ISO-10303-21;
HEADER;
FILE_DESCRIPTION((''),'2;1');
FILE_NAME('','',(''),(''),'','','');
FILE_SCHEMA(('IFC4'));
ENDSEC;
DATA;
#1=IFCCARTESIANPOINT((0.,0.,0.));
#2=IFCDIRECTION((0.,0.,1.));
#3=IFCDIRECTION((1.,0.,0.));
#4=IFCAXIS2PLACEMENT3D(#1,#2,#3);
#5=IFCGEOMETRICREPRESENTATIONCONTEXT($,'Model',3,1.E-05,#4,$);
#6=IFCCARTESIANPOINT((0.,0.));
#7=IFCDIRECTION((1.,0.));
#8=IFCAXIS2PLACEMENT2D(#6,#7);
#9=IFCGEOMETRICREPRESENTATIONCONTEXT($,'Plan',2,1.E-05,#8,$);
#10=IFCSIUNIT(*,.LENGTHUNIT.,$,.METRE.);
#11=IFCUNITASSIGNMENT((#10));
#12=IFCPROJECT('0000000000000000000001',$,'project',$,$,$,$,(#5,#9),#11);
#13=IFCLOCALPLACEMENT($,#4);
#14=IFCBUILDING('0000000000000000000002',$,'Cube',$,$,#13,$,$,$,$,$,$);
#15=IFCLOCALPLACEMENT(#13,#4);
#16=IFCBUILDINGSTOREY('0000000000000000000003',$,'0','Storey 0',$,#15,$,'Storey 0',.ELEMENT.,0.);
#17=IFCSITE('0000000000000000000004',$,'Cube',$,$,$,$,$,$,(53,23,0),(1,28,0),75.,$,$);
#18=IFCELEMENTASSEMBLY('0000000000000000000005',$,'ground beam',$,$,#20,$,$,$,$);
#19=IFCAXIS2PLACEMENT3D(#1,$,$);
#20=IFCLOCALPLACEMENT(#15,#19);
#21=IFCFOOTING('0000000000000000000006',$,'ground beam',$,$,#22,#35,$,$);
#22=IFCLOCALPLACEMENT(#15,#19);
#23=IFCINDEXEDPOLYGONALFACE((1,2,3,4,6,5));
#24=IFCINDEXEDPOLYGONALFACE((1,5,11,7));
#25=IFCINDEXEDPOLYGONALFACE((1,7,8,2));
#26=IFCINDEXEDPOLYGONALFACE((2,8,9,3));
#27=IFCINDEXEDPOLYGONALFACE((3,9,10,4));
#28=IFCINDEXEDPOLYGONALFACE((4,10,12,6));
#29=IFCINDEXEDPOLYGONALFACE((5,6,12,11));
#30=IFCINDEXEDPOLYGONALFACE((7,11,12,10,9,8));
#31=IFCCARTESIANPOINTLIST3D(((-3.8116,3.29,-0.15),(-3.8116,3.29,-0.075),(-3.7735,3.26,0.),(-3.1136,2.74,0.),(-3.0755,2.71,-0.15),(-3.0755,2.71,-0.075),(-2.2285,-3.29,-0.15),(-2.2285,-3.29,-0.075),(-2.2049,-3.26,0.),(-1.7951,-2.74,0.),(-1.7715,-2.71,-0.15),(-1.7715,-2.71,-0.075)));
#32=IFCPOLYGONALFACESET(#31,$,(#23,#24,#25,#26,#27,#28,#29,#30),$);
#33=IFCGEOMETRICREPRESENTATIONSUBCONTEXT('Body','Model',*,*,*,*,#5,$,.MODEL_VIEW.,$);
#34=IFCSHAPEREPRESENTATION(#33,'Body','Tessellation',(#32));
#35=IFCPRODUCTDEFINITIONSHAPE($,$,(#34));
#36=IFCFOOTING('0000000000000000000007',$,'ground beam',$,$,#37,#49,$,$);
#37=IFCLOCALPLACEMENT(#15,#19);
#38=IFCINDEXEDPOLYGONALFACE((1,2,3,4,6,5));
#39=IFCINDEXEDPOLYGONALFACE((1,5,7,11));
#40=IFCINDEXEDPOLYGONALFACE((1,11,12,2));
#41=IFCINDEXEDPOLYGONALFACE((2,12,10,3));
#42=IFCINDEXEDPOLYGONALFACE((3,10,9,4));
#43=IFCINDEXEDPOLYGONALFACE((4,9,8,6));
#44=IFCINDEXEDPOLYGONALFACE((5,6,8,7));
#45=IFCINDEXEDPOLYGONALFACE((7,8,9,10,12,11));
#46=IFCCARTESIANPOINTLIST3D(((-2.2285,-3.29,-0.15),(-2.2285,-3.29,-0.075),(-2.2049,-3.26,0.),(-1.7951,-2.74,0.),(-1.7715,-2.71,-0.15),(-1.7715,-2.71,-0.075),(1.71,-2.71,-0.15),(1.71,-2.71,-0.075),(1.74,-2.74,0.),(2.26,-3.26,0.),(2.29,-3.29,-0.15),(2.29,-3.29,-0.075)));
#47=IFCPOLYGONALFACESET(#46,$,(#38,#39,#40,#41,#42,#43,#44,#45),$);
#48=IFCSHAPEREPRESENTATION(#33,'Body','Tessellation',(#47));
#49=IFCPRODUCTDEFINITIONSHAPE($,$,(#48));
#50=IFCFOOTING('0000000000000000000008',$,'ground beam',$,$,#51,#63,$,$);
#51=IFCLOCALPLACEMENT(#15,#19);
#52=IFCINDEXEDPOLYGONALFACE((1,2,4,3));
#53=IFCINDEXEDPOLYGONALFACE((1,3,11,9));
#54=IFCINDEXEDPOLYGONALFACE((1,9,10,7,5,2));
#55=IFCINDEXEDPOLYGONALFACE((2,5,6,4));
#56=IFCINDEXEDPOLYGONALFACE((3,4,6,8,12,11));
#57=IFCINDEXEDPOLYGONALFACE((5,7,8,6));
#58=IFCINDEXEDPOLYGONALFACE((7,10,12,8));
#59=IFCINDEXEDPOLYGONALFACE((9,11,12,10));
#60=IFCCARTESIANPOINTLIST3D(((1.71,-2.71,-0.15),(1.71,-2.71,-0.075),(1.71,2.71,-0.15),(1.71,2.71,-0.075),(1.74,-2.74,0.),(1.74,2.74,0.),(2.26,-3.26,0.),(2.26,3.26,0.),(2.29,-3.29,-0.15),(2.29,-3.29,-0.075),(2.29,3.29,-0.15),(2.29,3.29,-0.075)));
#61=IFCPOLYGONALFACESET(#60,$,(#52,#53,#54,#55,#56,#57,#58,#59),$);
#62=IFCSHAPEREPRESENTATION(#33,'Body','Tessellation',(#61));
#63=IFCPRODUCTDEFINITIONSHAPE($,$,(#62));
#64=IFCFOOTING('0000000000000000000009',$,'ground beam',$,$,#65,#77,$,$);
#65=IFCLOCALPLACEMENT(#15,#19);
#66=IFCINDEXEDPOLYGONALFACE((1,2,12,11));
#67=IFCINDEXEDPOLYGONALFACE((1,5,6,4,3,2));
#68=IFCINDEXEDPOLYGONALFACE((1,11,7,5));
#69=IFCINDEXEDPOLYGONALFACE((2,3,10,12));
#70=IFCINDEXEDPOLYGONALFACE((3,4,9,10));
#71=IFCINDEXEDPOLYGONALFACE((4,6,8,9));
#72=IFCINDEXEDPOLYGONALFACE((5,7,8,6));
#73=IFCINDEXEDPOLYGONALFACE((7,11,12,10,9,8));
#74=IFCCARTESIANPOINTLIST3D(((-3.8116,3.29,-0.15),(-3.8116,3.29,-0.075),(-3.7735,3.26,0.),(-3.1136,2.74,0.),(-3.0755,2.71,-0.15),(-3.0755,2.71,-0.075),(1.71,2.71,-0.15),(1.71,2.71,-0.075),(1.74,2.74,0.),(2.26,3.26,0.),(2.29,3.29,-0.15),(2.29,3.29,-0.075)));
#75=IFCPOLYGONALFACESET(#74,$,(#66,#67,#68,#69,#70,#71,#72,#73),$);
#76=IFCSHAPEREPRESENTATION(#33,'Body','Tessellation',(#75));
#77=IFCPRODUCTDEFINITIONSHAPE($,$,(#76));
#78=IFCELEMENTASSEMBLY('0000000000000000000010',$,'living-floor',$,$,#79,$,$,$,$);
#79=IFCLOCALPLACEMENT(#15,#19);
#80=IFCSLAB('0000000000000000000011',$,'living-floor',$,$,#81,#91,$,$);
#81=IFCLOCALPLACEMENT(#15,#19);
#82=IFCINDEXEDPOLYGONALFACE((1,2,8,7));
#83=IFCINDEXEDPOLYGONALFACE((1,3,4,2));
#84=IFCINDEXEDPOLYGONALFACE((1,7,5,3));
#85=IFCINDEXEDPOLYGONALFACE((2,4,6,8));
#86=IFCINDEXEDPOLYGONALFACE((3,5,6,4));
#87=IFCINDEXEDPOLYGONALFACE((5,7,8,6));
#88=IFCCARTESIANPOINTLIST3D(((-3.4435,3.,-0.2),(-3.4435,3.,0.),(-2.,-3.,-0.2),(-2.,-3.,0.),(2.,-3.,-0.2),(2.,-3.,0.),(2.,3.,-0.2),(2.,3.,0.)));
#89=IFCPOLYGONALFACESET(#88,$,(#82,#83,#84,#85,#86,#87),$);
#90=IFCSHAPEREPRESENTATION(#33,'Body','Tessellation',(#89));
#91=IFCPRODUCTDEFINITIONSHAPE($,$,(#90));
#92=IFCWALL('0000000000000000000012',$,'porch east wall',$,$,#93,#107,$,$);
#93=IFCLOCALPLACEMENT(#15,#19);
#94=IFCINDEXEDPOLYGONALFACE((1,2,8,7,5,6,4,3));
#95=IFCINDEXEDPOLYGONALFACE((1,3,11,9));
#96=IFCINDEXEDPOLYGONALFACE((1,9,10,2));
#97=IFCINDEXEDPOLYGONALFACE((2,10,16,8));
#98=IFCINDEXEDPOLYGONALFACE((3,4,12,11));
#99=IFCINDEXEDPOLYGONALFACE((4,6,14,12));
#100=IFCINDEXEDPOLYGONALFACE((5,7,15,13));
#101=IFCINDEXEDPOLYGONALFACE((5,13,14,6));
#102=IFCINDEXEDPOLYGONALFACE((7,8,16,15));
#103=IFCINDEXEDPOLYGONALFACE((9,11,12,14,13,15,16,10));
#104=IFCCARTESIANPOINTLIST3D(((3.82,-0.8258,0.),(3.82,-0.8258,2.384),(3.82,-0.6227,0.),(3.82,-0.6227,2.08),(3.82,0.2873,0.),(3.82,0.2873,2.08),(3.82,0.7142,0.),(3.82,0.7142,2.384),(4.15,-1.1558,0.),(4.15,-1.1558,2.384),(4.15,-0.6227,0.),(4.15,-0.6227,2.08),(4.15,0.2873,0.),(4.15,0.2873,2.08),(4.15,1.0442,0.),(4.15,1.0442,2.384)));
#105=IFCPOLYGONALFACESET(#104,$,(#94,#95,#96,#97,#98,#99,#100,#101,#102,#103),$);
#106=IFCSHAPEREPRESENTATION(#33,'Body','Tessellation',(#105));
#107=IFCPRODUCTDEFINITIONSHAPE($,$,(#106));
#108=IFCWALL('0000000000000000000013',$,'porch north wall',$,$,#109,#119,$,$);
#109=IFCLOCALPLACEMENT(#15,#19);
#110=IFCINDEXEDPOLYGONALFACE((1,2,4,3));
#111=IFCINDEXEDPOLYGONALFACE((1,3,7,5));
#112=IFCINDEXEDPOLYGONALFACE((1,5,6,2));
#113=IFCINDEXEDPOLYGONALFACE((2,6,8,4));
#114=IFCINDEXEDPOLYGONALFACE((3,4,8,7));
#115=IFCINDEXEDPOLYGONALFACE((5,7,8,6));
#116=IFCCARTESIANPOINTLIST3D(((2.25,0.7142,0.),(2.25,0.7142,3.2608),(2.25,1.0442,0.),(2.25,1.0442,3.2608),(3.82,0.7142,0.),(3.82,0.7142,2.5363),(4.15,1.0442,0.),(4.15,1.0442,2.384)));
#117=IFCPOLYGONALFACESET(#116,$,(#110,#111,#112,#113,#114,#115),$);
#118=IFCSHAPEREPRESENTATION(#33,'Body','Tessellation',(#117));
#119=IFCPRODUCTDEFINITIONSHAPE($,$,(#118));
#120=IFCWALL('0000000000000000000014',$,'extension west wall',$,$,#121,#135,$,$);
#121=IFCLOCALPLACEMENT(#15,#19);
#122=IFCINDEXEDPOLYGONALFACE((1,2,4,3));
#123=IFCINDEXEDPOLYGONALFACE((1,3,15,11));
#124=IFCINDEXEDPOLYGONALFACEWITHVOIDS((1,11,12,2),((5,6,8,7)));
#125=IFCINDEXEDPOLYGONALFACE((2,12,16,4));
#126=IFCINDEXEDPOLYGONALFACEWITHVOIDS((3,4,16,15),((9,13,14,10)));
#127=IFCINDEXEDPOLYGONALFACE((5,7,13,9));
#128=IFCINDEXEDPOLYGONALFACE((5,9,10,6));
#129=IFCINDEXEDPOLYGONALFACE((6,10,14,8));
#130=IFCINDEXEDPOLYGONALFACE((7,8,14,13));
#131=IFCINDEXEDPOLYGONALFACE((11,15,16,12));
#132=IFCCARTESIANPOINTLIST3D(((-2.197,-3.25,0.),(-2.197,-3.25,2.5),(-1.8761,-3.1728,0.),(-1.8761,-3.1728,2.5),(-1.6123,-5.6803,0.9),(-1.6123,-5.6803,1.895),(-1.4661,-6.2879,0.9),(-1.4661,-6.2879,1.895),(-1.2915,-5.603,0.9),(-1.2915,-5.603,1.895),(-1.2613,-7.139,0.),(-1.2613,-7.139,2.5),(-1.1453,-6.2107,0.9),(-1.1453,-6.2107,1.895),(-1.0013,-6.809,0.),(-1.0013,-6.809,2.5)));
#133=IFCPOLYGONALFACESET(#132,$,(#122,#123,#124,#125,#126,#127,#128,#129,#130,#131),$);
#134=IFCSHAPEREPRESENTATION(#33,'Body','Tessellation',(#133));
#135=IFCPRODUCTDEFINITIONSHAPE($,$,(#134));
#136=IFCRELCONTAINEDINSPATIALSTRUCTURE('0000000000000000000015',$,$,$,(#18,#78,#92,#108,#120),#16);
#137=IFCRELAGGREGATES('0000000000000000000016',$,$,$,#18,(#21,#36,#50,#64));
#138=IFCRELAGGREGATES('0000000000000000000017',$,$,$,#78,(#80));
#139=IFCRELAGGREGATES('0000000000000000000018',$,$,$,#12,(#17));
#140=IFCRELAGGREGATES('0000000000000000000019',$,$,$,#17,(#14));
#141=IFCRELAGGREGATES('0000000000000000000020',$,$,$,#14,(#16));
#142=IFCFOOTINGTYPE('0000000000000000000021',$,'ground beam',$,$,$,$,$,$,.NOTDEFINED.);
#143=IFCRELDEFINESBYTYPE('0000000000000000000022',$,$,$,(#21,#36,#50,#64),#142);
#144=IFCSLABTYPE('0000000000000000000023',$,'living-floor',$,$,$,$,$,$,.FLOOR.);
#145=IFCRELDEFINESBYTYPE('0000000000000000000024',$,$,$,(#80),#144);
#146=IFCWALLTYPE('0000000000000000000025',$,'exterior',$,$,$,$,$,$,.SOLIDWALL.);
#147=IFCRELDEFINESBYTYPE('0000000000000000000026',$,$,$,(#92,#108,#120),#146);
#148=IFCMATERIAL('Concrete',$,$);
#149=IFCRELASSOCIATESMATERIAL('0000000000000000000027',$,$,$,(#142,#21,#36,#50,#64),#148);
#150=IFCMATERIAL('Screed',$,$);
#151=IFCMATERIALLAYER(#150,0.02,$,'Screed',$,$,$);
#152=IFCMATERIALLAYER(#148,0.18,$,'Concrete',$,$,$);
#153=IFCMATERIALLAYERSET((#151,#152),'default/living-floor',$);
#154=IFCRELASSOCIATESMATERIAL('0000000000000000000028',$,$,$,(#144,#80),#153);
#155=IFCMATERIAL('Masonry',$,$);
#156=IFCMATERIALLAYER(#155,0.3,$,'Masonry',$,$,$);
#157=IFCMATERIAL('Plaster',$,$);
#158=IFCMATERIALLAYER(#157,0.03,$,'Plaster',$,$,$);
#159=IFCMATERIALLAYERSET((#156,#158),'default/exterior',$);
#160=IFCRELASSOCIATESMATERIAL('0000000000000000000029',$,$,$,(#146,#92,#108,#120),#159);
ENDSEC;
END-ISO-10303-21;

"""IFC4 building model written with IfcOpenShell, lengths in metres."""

from ifc_helpers import new_model, si_unit, frame, origin, origin_with_axes, origin_2d_with_axis, place, context, subcontext, project, spatial, polyline, line, indexed_curve, outline, extrude, clip, halfspace, source, transform, mapped, material, layer, layer_set, layer_usage, material_profile, profile_set, profile_usage, type_object, element, aggregate, save


model = new_model("IFC4")

# Units and contexts
model_context = context("Model", 3, precision=1e-05, world=origin_with_axes())
plan_context = context("Plan", 2, precision=1e-05, world=origin_2d_with_axis())
body_context = subcontext(model_context, "Body", "Model", "MODEL_VIEW")
ifc_project = project(units=[si_unit("LENGTHUNIT", "METRE")], contexts=[model_context, plan_context])

# Site, building, storey
site = spatial("IfcSite", under=ifc_project, Name="Cube", RefLatitude=(53, 23, 0), RefLongitude=(1, 28, 0), RefElevation=75.0)
building_placement = place(None, origin_with_axes())
building = spatial("IfcBuilding", under=site, at=building_placement, Name="Cube")
storey_placement = place(building_placement, origin_with_axes())
storey = spatial("IfcBuildingStorey", under=building, at=storey_placement, Name="0", Description="Storey 0", LongName="Storey 0", CompositionType="ELEMENT", Elevation=0.0)

# Element assembly, footings
assembly_1_placement = place(storey_placement, origin_with_axes())
assembly_1 = element("IfcElementAssembly", 1, at=assembly_1_placement, inside=storey, Name="ground beam")
ifc_material_1 = material(Name="Concrete")
ifc_material_profile = material_profile(ifc_material_1, outline(polyline([(-0.26, 0.0), (-0.29, -0.075), (-0.29, -0.15), (0.29, -0.15), (0.29, -0.075), (0.26, 0.0), (-0.26, 0.0)])))
ifc_profile_set = profile_set([ifc_material_profile])
ifc_profile_usage_1 = profile_usage(ifc_profile_set)
footing_type = type_object("IfcFootingType", Name="ground beam", PredefinedType="NOTDEFINED", material=ifc_profile_set)
footing_1_placement = place(assembly_1_placement, frame((-1.7661, -3.9723, 0.0), z_axis=(-0.233915, 0.972257, 0.0), x_axis=(-0.972257, -0.233915, 0.0)))
footing_1 = element("IfcFooting", 2, at=footing_1_placement, type_object=footing_type, material=ifc_profile_usage_1, Name="ground beam", context=body_context, shape_type="Clipping", body=[
    clip(clip(extrude(outline(polyline([(-0.26, 0.0), (-0.29, -0.075), (-0.29, -0.15), (0.29, -0.15), (0.29, -0.075), (0.26, 0.0), (-0.26, 0.0)])), origin_with_axes(), (0.0, 0.0, 1.0), 8.1712), halfspace(frame((0.0, 0.0, 1.0), z_axis=(-0.618904, 0.0, -0.785467), x_axis=(0.0, 1.0, 0.0)), False)), halfspace(frame((0.0, 0.0, 7.1712), z_axis=(-0.785467, 0.0, 0.618904), x_axis=(0.0, 1.0, 0.0)), False)),
])
ifc_profile_usage_2 = profile_usage(ifc_profile_set)
footing_2_placement = place(assembly_1_placement, frame((3.0, -3.0, 0.0), z_axis=(-1.0, 0.0, 0.0), x_axis=(0.0, -1.0, 0.0)))
footing_2 = element("IfcFooting", 3, at=footing_2_placement, type_object=footing_type, material=ifc_profile_usage_2, Name="ground beam", context=body_context, shape_type="Clipping", body=[
    clip(clip(extrude(outline(polyline([(-0.26, 0.0), (-0.29, -0.075), (-0.29, -0.15), (0.29, -0.15), (0.29, -0.075), (0.26, 0.0), (-0.26, 0.0)])), origin_with_axes(), (0.0, 0.0, 1.0), 6.0), halfspace(frame((0.0, 0.0, 1.0), z_axis=(-0.707107, 0.0, -0.707107), x_axis=(0.0, 1.0, 0.0)), False)), halfspace(frame((0.0, 0.0, 5.0), z_axis=(-0.618904, 0.0, 0.785467), x_axis=(0.0, 1.0, 0.0)), False)),
])
ifc_profile_usage_3 = profile_usage(ifc_profile_set)
footing_3_placement = place(assembly_1_placement, frame((2.0, 4.0, 0.0), z_axis=(0.0, -1.0, 0.0), x_axis=(1.0, 0.0, 0.0)))
footing_3 = element("IfcFooting", 4, at=footing_3_placement, type_object=footing_type, material=ifc_profile_usage_3, Name="ground beam", context=body_context, shape_type="Clipping", body=[
    clip(clip(extrude(outline(polyline([(-0.26, 0.0), (-0.29, -0.075), (-0.29, -0.15), (0.29, -0.15), (0.29, -0.075), (0.26, 0.0), (-0.26, 0.0)])), origin_with_axes(), (0.0, 0.0, 1.0), 8.0), halfspace(frame((0.0, 0.0, 1.0), z_axis=(-0.707107, 0.0, -0.707107), x_axis=(0.0, 1.0, 0.0)), False)), halfspace(frame((0.0, 0.0, 7.0), z_axis=(-0.707107, 0.0, 0.707107), x_axis=(0.0, 1.0, 0.0)), False)),
])
ifc_profile_usage_4 = profile_usage(ifc_profile_set)
footing_4_placement = place(assembly_1_placement, frame((-4.4435, 3.0, 0.0), z_axis=(1.0, 0.0, 0.0), x_axis=(0.0, 1.0, 0.0)))
footing_4 = element("IfcFooting", 5, at=footing_4_placement, type_object=footing_type, material=ifc_profile_usage_4, Name="ground beam", context=body_context, shape_type="Clipping", body=[
    clip(clip(extrude(outline(polyline([(-0.26, 0.0), (-0.29, -0.075), (-0.29, -0.15), (0.29, -0.15), (0.29, -0.075), (0.26, 0.0), (-0.26, 0.0)])), origin_with_axes(), (0.0, 0.0, 1.0), 7.4435), halfspace(frame((0.0, 0.0, 1.0), z_axis=(-0.785467, 0.0, -0.618904), x_axis=(0.0, 1.0, 0.0)), False)), halfspace(frame((0.0, 0.0, 6.4435), z_axis=(-0.707107, 0.0, 0.707107), x_axis=(0.0, 1.0, 0.0)), False)),
])
aggregate(assembly_1, [footing_1, footing_2, footing_3, footing_4])

# Element assembly, slab
assembly_2_placement = place(storey_placement, origin_with_axes())
assembly_2 = element("IfcElementAssembly", 6, at=assembly_2_placement, inside=storey, Name="living-floor")
ifc_material_2 = material(Name="Screed")
ifc_layer_1 = layer(ifc_material_2, 0.02, Name="Screed")
ifc_layer_2 = layer(ifc_material_1, 0.18, Name="Concrete")
ifc_layer_set_1 = layer_set([ifc_layer_1, ifc_layer_2], Name="default/living-floor")
ifc_layer_usage_1 = layer_usage(ifc_layer_set_1, "AXIS3", "POSITIVE", 0.0)
slab_type = type_object("IfcSlabType", Name="living-floor", PredefinedType="FLOOR", material=ifc_layer_set_1)
slab_placement = place(assembly_2_placement, frame((2.0, 3.0, -0.2), z_axis=(0.0, 0.0, -1.0), x_axis=(0.0, 1.0, 0.0)))
slab = element("IfcSlab", 7, at=slab_placement, type_object=slab_type, material=ifc_layer_usage_1, Name="living-floor", context=body_context, shape_type="SweptSolid", body=[
    extrude(outline(polyline([(0.0, 0.0), (-6.0, 0.0), (-6.0, -4.0), (0.0, -5.4435), (0.0, 0.0)])), origin(), (0.0, 0.0, -1.0), 0.2),
])
aggregate(assembly_2, [slab])

# Wall, opening
ifc_material_3 = material(Name="Masonry")
ifc_layer_3 = layer(ifc_material_3, 0.3, Name="Masonry")
ifc_material_4 = material(Name="Plaster")
ifc_layer_4 = layer(ifc_material_4, 0.03, Name="Plaster")
ifc_layer_set_2 = layer_set([ifc_layer_3, ifc_layer_4], Name="default/exterior")
wall_type = type_object("IfcWallType", Name="exterior", PredefinedType="SOLIDWALL", material=ifc_layer_set_2)
ifc_layer_usage_2 = layer_usage(ifc_layer_set_2, "AXIS2", "POSITIVE", 0.0)
wall_1_placement = place(storey_placement, frame((4.15, -1.1558, 0.0), z_axis=(0.0, 0.0, 1.0), x_axis=(0.0, 1.0, 0.0)))
wall_1 = element("IfcWall", 8, at=wall_1_placement, inside=storey, type_object=wall_type, material=ifc_layer_usage_2, Name="porch east wall", context=body_context, shape_type="SweptSolid", body=[
    extrude(outline(indexed_curve([(0.0, 0.0), (0.33, 0.33), (1.87, 0.33), (2.2, 0.0)], segments=[line(1, 2, 3, 4, 1)])), origin_with_axes(), (0.0, 0.0, 1.0), 2.384),
])
shared_shape = source(origin_with_axes(), body_context, "Body", "SweptSolid", [
    extrude(outline(indexed_curve([(0.0, 0.0), (0.91, 0.0), (0.91, 2.08), (0.0, 2.08)], segments=[line(1, 2, 3, 4, 1)])), frame((0.0, -0.6, 0.0), z_axis=(0.0, -1.0, 0.0), x_axis=(1.0, 0.0, 0.0)), (0.0, 0.0, -1.0), 1.2),
])
opening_1_placement = place(wall_1_placement, frame((0.5331, 0.0, 0.0), z_axis=(0.0, 0.0, 1.0), x_axis=(1.0, 0.0, 0.0)))
element("IfcOpeningElement", 9, at=opening_1_placement, cuts=wall_1, PredefinedType="OPENING", context=body_context, shape_type="MappedRepresentation", body=[
    mapped(shared_shape, transform((0.0, 0.0, 0.0), x_axis=(1.0, 0.0, 0.0), y_axis=(0.0, 1.0, 0.0), z_axis=(0.0, 0.0, 1.0), scale=1.0)),
])

# Wall
ifc_layer_usage_3 = layer_usage(ifc_layer_set_2, "AXIS2", "POSITIVE", 0.0)
wall_2_placement = place(storey_placement, frame((4.15, 1.0442, 0.0), z_axis=(0.0, 0.0, 1.0), x_axis=(-1.0, 0.0, 0.0)))
element("IfcWall", 10, at=wall_2_placement, inside=storey, type_object=wall_type, material=ifc_layer_usage_3, Name="porch north wall", context=body_context, shape_type="Clipping", body=[
    clip(extrude(outline(indexed_curve([(0.0, 0.0), (1.9, 0.0), (1.9, 0.33), (0.33, 0.33)], segments=[line(1, 2, 3, 4, 1)])), origin_with_axes(), (0.0, 0.0, 1.0), 3.5), halfspace(frame((0.0, 0.0, 2.384), z_axis=(-0.419, 0.0, 0.908), x_axis=(0.0, 1.0, 0.0)), False)),
])

# Wall, opening
ifc_layer_usage_4 = layer_usage(ifc_layer_set_2, "AXIS2", "POSITIVE", 0.0)
wall_3_placement = place(storey_placement, frame((-2.197, -3.25, 0.0), z_axis=(0.0, 0.0, 1.0), x_axis=(0.233916, -0.972257, 0.0)))
wall_3 = element("IfcWall", 11, at=wall_3_placement, inside=storey, type_object=wall_type, material=ifc_layer_usage_4, Name="extension west wall", context=body_context, shape_type="SweptSolid", body=[
    extrude(outline(indexed_curve([(0.0, 0.0), (0.0, 0.33), (3.7399, 0.33), (4.0, 0.0)], segments=[line(1, 2, 3, 4, 1)])), origin_with_axes(), (0.0, 0.0, 1.0), 2.5),
])
opening_2_placement = place(wall_3_placement, frame((2.4996, -0.0501, 0.9), z_axis=(0.0, 0.0, 1.0), x_axis=(1.0, 0.000142, 0.0)))
element("IfcOpeningElement", 12, at=opening_2_placement, cuts=wall_3, PredefinedType="OPENING", context=body_context, shape_type="SweptSolid", body=[
    extrude(outline(indexed_curve([(0.0, 0.0), (0.0, 0.43), (0.625, 0.43), (0.625, 0.0), (0.0, 0.0)], self_intersect=False)), origin_with_axes(), (0.0, 0.0, 1.0), 0.995),
])

save(model, "model.ifc")
